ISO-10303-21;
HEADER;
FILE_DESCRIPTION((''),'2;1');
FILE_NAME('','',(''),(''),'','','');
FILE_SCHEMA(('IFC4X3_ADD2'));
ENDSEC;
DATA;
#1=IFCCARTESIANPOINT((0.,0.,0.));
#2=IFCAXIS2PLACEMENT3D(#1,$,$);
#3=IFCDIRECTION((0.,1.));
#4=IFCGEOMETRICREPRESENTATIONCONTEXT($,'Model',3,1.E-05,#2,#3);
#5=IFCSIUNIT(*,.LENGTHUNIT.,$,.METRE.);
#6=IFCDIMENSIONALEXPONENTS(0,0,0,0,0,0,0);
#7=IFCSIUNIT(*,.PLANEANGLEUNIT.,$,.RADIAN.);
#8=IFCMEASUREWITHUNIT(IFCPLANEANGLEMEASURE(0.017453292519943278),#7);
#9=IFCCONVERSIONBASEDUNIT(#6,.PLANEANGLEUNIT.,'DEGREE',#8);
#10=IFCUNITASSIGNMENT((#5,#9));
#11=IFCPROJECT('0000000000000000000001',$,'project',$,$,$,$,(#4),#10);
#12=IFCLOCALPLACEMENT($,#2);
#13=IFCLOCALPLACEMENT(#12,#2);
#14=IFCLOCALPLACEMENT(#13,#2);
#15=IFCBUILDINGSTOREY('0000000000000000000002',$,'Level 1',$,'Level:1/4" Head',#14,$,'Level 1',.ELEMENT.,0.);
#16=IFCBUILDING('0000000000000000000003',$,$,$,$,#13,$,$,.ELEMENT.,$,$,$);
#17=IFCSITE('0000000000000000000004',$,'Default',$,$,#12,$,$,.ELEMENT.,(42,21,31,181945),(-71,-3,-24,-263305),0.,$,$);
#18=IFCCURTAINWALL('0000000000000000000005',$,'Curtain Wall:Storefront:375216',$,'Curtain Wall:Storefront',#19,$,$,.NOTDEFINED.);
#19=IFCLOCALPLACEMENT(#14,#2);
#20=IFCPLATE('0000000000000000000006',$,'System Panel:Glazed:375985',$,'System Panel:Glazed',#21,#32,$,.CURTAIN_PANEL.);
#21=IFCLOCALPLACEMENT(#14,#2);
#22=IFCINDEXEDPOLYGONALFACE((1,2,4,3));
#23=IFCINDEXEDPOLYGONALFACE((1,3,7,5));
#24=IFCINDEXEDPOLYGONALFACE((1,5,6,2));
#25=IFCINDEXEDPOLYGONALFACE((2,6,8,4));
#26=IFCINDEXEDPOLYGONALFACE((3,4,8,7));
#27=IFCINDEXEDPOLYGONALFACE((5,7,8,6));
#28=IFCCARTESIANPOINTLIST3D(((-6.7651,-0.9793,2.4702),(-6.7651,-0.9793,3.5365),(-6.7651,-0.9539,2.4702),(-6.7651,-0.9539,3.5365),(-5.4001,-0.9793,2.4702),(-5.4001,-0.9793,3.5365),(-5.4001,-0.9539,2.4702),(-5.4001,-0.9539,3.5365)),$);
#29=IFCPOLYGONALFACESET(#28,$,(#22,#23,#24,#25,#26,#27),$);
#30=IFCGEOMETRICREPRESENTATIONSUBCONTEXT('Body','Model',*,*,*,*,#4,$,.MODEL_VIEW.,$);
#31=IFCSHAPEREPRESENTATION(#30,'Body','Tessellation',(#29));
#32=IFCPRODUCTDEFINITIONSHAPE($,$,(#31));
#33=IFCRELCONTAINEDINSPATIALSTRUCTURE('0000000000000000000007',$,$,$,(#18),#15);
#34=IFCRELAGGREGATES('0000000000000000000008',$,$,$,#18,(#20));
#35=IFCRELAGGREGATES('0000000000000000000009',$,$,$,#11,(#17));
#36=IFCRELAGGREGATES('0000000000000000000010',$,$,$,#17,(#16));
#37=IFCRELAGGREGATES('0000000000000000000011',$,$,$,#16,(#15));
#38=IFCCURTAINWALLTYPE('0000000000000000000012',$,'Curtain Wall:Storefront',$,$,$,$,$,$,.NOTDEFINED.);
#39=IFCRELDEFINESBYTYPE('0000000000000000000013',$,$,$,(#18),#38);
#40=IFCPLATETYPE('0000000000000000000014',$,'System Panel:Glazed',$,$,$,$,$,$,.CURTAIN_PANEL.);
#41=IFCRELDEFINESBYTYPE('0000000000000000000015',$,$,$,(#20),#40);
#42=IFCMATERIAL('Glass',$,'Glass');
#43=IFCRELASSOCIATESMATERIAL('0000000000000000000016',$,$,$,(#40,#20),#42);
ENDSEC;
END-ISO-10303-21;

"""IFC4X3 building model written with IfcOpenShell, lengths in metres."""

from ifc_helpers import new_model, entity, si_unit, converted_unit, direction, frame, frame_2d, origin, place, context, subcontext, project, spatial, rectangle, extrude, source, transform, mapped, material, type_object, type_shapes, element, aggregate, save


model = new_model("IFC4X3")

# Units and contexts
model_context = context("Model", 3, precision=1e-05, world=origin(), true_north=direction((0.0, 1.0)))
body_context = subcontext(model_context, "Body", "Model", "MODEL_VIEW")
ifc_project = project(units=[si_unit("LENGTHUNIT", "METRE"), converted_unit("PLANEANGLEUNIT", "DEGREE", entity("IfcPlaneAngleMeasure", 0.017453292519943278), si_unit("PLANEANGLEUNIT", "RADIAN"), dimensions=[0, 0, 0, 0, 0, 0, 0])], contexts=[model_context])

# Site, building, storey
site_placement = place(None, origin())
site = spatial("IfcSite", under=ifc_project, at=site_placement, Name="Default", CompositionType="ELEMENT", RefLatitude=(42, 21, 31, 181945), RefLongitude=(-71, -3, -24, -263305), RefElevation=0.0)
building_placement = place(site_placement, origin())
building = spatial("IfcBuilding", under=site, at=building_placement, CompositionType="ELEMENT")
storey_placement = place(building_placement, origin())
storey = spatial("IfcBuildingStorey", under=building, at=storey_placement, Name="Level 1", ObjectType="Level:1/4\" Head", LongName="Level 1", CompositionType="ELEMENT", Elevation=0.0)

# Curtain wall, plate
curtain_wall_type = type_object("IfcCurtainWallType", Name="Curtain Wall:Storefront", PredefinedType="NOTDEFINED")
curtain_wall_placement = place(storey_placement, origin())
curtain_wall = element("IfcCurtainWall", 1, at=curtain_wall_placement, inside=storey, type_object=curtain_wall_type, Name="Curtain Wall:Storefront:375216", ObjectType="Curtain Wall:Storefront", PredefinedType="NOTDEFINED")
ifc_material_1 = material(Name="Glass", Category="Glass")
plate_type_1 = type_object("IfcPlateType", Name="System Panel:Glazed", PredefinedType="CURTAIN_PANEL", material=ifc_material_1)
shared_shape_1 = source(origin(), body_context, "Body", "SweptSolid", [
    extrude(rectangle(XDim=0.0254, YDim=1.3651, at=frame_2d((0.0, 0.0), x_axis=(1.0, 0.0))), frame((0.6825, 0.0127, 0.0), z_axis=(0.0, 0.0, 1.0), x_axis=(0.0, 1.0, 0.0)), (0.0, 0.0, 1.0), 1.0663),
])
type_shapes(plate_type_1, [shared_shape_1])
plate_1_placement = place(curtain_wall_placement, frame((-6.7651, -0.9793, 2.4701)))
plate_1 = element("IfcPlate", 2, at=plate_1_placement, type_object=plate_type_1, material=ifc_material_1, Name="System Panel:Glazed:375985", ObjectType="System Panel:Glazed", PredefinedType="CURTAIN_PANEL", context=body_context, shape_type="MappedRepresentation", body=[
    mapped(shared_shape_1, transform((0.0, 0.0, 0.0), scale=1.0)),
])
aggregate(curtain_wall, [plate_1])

save(model, "model.ifc")
